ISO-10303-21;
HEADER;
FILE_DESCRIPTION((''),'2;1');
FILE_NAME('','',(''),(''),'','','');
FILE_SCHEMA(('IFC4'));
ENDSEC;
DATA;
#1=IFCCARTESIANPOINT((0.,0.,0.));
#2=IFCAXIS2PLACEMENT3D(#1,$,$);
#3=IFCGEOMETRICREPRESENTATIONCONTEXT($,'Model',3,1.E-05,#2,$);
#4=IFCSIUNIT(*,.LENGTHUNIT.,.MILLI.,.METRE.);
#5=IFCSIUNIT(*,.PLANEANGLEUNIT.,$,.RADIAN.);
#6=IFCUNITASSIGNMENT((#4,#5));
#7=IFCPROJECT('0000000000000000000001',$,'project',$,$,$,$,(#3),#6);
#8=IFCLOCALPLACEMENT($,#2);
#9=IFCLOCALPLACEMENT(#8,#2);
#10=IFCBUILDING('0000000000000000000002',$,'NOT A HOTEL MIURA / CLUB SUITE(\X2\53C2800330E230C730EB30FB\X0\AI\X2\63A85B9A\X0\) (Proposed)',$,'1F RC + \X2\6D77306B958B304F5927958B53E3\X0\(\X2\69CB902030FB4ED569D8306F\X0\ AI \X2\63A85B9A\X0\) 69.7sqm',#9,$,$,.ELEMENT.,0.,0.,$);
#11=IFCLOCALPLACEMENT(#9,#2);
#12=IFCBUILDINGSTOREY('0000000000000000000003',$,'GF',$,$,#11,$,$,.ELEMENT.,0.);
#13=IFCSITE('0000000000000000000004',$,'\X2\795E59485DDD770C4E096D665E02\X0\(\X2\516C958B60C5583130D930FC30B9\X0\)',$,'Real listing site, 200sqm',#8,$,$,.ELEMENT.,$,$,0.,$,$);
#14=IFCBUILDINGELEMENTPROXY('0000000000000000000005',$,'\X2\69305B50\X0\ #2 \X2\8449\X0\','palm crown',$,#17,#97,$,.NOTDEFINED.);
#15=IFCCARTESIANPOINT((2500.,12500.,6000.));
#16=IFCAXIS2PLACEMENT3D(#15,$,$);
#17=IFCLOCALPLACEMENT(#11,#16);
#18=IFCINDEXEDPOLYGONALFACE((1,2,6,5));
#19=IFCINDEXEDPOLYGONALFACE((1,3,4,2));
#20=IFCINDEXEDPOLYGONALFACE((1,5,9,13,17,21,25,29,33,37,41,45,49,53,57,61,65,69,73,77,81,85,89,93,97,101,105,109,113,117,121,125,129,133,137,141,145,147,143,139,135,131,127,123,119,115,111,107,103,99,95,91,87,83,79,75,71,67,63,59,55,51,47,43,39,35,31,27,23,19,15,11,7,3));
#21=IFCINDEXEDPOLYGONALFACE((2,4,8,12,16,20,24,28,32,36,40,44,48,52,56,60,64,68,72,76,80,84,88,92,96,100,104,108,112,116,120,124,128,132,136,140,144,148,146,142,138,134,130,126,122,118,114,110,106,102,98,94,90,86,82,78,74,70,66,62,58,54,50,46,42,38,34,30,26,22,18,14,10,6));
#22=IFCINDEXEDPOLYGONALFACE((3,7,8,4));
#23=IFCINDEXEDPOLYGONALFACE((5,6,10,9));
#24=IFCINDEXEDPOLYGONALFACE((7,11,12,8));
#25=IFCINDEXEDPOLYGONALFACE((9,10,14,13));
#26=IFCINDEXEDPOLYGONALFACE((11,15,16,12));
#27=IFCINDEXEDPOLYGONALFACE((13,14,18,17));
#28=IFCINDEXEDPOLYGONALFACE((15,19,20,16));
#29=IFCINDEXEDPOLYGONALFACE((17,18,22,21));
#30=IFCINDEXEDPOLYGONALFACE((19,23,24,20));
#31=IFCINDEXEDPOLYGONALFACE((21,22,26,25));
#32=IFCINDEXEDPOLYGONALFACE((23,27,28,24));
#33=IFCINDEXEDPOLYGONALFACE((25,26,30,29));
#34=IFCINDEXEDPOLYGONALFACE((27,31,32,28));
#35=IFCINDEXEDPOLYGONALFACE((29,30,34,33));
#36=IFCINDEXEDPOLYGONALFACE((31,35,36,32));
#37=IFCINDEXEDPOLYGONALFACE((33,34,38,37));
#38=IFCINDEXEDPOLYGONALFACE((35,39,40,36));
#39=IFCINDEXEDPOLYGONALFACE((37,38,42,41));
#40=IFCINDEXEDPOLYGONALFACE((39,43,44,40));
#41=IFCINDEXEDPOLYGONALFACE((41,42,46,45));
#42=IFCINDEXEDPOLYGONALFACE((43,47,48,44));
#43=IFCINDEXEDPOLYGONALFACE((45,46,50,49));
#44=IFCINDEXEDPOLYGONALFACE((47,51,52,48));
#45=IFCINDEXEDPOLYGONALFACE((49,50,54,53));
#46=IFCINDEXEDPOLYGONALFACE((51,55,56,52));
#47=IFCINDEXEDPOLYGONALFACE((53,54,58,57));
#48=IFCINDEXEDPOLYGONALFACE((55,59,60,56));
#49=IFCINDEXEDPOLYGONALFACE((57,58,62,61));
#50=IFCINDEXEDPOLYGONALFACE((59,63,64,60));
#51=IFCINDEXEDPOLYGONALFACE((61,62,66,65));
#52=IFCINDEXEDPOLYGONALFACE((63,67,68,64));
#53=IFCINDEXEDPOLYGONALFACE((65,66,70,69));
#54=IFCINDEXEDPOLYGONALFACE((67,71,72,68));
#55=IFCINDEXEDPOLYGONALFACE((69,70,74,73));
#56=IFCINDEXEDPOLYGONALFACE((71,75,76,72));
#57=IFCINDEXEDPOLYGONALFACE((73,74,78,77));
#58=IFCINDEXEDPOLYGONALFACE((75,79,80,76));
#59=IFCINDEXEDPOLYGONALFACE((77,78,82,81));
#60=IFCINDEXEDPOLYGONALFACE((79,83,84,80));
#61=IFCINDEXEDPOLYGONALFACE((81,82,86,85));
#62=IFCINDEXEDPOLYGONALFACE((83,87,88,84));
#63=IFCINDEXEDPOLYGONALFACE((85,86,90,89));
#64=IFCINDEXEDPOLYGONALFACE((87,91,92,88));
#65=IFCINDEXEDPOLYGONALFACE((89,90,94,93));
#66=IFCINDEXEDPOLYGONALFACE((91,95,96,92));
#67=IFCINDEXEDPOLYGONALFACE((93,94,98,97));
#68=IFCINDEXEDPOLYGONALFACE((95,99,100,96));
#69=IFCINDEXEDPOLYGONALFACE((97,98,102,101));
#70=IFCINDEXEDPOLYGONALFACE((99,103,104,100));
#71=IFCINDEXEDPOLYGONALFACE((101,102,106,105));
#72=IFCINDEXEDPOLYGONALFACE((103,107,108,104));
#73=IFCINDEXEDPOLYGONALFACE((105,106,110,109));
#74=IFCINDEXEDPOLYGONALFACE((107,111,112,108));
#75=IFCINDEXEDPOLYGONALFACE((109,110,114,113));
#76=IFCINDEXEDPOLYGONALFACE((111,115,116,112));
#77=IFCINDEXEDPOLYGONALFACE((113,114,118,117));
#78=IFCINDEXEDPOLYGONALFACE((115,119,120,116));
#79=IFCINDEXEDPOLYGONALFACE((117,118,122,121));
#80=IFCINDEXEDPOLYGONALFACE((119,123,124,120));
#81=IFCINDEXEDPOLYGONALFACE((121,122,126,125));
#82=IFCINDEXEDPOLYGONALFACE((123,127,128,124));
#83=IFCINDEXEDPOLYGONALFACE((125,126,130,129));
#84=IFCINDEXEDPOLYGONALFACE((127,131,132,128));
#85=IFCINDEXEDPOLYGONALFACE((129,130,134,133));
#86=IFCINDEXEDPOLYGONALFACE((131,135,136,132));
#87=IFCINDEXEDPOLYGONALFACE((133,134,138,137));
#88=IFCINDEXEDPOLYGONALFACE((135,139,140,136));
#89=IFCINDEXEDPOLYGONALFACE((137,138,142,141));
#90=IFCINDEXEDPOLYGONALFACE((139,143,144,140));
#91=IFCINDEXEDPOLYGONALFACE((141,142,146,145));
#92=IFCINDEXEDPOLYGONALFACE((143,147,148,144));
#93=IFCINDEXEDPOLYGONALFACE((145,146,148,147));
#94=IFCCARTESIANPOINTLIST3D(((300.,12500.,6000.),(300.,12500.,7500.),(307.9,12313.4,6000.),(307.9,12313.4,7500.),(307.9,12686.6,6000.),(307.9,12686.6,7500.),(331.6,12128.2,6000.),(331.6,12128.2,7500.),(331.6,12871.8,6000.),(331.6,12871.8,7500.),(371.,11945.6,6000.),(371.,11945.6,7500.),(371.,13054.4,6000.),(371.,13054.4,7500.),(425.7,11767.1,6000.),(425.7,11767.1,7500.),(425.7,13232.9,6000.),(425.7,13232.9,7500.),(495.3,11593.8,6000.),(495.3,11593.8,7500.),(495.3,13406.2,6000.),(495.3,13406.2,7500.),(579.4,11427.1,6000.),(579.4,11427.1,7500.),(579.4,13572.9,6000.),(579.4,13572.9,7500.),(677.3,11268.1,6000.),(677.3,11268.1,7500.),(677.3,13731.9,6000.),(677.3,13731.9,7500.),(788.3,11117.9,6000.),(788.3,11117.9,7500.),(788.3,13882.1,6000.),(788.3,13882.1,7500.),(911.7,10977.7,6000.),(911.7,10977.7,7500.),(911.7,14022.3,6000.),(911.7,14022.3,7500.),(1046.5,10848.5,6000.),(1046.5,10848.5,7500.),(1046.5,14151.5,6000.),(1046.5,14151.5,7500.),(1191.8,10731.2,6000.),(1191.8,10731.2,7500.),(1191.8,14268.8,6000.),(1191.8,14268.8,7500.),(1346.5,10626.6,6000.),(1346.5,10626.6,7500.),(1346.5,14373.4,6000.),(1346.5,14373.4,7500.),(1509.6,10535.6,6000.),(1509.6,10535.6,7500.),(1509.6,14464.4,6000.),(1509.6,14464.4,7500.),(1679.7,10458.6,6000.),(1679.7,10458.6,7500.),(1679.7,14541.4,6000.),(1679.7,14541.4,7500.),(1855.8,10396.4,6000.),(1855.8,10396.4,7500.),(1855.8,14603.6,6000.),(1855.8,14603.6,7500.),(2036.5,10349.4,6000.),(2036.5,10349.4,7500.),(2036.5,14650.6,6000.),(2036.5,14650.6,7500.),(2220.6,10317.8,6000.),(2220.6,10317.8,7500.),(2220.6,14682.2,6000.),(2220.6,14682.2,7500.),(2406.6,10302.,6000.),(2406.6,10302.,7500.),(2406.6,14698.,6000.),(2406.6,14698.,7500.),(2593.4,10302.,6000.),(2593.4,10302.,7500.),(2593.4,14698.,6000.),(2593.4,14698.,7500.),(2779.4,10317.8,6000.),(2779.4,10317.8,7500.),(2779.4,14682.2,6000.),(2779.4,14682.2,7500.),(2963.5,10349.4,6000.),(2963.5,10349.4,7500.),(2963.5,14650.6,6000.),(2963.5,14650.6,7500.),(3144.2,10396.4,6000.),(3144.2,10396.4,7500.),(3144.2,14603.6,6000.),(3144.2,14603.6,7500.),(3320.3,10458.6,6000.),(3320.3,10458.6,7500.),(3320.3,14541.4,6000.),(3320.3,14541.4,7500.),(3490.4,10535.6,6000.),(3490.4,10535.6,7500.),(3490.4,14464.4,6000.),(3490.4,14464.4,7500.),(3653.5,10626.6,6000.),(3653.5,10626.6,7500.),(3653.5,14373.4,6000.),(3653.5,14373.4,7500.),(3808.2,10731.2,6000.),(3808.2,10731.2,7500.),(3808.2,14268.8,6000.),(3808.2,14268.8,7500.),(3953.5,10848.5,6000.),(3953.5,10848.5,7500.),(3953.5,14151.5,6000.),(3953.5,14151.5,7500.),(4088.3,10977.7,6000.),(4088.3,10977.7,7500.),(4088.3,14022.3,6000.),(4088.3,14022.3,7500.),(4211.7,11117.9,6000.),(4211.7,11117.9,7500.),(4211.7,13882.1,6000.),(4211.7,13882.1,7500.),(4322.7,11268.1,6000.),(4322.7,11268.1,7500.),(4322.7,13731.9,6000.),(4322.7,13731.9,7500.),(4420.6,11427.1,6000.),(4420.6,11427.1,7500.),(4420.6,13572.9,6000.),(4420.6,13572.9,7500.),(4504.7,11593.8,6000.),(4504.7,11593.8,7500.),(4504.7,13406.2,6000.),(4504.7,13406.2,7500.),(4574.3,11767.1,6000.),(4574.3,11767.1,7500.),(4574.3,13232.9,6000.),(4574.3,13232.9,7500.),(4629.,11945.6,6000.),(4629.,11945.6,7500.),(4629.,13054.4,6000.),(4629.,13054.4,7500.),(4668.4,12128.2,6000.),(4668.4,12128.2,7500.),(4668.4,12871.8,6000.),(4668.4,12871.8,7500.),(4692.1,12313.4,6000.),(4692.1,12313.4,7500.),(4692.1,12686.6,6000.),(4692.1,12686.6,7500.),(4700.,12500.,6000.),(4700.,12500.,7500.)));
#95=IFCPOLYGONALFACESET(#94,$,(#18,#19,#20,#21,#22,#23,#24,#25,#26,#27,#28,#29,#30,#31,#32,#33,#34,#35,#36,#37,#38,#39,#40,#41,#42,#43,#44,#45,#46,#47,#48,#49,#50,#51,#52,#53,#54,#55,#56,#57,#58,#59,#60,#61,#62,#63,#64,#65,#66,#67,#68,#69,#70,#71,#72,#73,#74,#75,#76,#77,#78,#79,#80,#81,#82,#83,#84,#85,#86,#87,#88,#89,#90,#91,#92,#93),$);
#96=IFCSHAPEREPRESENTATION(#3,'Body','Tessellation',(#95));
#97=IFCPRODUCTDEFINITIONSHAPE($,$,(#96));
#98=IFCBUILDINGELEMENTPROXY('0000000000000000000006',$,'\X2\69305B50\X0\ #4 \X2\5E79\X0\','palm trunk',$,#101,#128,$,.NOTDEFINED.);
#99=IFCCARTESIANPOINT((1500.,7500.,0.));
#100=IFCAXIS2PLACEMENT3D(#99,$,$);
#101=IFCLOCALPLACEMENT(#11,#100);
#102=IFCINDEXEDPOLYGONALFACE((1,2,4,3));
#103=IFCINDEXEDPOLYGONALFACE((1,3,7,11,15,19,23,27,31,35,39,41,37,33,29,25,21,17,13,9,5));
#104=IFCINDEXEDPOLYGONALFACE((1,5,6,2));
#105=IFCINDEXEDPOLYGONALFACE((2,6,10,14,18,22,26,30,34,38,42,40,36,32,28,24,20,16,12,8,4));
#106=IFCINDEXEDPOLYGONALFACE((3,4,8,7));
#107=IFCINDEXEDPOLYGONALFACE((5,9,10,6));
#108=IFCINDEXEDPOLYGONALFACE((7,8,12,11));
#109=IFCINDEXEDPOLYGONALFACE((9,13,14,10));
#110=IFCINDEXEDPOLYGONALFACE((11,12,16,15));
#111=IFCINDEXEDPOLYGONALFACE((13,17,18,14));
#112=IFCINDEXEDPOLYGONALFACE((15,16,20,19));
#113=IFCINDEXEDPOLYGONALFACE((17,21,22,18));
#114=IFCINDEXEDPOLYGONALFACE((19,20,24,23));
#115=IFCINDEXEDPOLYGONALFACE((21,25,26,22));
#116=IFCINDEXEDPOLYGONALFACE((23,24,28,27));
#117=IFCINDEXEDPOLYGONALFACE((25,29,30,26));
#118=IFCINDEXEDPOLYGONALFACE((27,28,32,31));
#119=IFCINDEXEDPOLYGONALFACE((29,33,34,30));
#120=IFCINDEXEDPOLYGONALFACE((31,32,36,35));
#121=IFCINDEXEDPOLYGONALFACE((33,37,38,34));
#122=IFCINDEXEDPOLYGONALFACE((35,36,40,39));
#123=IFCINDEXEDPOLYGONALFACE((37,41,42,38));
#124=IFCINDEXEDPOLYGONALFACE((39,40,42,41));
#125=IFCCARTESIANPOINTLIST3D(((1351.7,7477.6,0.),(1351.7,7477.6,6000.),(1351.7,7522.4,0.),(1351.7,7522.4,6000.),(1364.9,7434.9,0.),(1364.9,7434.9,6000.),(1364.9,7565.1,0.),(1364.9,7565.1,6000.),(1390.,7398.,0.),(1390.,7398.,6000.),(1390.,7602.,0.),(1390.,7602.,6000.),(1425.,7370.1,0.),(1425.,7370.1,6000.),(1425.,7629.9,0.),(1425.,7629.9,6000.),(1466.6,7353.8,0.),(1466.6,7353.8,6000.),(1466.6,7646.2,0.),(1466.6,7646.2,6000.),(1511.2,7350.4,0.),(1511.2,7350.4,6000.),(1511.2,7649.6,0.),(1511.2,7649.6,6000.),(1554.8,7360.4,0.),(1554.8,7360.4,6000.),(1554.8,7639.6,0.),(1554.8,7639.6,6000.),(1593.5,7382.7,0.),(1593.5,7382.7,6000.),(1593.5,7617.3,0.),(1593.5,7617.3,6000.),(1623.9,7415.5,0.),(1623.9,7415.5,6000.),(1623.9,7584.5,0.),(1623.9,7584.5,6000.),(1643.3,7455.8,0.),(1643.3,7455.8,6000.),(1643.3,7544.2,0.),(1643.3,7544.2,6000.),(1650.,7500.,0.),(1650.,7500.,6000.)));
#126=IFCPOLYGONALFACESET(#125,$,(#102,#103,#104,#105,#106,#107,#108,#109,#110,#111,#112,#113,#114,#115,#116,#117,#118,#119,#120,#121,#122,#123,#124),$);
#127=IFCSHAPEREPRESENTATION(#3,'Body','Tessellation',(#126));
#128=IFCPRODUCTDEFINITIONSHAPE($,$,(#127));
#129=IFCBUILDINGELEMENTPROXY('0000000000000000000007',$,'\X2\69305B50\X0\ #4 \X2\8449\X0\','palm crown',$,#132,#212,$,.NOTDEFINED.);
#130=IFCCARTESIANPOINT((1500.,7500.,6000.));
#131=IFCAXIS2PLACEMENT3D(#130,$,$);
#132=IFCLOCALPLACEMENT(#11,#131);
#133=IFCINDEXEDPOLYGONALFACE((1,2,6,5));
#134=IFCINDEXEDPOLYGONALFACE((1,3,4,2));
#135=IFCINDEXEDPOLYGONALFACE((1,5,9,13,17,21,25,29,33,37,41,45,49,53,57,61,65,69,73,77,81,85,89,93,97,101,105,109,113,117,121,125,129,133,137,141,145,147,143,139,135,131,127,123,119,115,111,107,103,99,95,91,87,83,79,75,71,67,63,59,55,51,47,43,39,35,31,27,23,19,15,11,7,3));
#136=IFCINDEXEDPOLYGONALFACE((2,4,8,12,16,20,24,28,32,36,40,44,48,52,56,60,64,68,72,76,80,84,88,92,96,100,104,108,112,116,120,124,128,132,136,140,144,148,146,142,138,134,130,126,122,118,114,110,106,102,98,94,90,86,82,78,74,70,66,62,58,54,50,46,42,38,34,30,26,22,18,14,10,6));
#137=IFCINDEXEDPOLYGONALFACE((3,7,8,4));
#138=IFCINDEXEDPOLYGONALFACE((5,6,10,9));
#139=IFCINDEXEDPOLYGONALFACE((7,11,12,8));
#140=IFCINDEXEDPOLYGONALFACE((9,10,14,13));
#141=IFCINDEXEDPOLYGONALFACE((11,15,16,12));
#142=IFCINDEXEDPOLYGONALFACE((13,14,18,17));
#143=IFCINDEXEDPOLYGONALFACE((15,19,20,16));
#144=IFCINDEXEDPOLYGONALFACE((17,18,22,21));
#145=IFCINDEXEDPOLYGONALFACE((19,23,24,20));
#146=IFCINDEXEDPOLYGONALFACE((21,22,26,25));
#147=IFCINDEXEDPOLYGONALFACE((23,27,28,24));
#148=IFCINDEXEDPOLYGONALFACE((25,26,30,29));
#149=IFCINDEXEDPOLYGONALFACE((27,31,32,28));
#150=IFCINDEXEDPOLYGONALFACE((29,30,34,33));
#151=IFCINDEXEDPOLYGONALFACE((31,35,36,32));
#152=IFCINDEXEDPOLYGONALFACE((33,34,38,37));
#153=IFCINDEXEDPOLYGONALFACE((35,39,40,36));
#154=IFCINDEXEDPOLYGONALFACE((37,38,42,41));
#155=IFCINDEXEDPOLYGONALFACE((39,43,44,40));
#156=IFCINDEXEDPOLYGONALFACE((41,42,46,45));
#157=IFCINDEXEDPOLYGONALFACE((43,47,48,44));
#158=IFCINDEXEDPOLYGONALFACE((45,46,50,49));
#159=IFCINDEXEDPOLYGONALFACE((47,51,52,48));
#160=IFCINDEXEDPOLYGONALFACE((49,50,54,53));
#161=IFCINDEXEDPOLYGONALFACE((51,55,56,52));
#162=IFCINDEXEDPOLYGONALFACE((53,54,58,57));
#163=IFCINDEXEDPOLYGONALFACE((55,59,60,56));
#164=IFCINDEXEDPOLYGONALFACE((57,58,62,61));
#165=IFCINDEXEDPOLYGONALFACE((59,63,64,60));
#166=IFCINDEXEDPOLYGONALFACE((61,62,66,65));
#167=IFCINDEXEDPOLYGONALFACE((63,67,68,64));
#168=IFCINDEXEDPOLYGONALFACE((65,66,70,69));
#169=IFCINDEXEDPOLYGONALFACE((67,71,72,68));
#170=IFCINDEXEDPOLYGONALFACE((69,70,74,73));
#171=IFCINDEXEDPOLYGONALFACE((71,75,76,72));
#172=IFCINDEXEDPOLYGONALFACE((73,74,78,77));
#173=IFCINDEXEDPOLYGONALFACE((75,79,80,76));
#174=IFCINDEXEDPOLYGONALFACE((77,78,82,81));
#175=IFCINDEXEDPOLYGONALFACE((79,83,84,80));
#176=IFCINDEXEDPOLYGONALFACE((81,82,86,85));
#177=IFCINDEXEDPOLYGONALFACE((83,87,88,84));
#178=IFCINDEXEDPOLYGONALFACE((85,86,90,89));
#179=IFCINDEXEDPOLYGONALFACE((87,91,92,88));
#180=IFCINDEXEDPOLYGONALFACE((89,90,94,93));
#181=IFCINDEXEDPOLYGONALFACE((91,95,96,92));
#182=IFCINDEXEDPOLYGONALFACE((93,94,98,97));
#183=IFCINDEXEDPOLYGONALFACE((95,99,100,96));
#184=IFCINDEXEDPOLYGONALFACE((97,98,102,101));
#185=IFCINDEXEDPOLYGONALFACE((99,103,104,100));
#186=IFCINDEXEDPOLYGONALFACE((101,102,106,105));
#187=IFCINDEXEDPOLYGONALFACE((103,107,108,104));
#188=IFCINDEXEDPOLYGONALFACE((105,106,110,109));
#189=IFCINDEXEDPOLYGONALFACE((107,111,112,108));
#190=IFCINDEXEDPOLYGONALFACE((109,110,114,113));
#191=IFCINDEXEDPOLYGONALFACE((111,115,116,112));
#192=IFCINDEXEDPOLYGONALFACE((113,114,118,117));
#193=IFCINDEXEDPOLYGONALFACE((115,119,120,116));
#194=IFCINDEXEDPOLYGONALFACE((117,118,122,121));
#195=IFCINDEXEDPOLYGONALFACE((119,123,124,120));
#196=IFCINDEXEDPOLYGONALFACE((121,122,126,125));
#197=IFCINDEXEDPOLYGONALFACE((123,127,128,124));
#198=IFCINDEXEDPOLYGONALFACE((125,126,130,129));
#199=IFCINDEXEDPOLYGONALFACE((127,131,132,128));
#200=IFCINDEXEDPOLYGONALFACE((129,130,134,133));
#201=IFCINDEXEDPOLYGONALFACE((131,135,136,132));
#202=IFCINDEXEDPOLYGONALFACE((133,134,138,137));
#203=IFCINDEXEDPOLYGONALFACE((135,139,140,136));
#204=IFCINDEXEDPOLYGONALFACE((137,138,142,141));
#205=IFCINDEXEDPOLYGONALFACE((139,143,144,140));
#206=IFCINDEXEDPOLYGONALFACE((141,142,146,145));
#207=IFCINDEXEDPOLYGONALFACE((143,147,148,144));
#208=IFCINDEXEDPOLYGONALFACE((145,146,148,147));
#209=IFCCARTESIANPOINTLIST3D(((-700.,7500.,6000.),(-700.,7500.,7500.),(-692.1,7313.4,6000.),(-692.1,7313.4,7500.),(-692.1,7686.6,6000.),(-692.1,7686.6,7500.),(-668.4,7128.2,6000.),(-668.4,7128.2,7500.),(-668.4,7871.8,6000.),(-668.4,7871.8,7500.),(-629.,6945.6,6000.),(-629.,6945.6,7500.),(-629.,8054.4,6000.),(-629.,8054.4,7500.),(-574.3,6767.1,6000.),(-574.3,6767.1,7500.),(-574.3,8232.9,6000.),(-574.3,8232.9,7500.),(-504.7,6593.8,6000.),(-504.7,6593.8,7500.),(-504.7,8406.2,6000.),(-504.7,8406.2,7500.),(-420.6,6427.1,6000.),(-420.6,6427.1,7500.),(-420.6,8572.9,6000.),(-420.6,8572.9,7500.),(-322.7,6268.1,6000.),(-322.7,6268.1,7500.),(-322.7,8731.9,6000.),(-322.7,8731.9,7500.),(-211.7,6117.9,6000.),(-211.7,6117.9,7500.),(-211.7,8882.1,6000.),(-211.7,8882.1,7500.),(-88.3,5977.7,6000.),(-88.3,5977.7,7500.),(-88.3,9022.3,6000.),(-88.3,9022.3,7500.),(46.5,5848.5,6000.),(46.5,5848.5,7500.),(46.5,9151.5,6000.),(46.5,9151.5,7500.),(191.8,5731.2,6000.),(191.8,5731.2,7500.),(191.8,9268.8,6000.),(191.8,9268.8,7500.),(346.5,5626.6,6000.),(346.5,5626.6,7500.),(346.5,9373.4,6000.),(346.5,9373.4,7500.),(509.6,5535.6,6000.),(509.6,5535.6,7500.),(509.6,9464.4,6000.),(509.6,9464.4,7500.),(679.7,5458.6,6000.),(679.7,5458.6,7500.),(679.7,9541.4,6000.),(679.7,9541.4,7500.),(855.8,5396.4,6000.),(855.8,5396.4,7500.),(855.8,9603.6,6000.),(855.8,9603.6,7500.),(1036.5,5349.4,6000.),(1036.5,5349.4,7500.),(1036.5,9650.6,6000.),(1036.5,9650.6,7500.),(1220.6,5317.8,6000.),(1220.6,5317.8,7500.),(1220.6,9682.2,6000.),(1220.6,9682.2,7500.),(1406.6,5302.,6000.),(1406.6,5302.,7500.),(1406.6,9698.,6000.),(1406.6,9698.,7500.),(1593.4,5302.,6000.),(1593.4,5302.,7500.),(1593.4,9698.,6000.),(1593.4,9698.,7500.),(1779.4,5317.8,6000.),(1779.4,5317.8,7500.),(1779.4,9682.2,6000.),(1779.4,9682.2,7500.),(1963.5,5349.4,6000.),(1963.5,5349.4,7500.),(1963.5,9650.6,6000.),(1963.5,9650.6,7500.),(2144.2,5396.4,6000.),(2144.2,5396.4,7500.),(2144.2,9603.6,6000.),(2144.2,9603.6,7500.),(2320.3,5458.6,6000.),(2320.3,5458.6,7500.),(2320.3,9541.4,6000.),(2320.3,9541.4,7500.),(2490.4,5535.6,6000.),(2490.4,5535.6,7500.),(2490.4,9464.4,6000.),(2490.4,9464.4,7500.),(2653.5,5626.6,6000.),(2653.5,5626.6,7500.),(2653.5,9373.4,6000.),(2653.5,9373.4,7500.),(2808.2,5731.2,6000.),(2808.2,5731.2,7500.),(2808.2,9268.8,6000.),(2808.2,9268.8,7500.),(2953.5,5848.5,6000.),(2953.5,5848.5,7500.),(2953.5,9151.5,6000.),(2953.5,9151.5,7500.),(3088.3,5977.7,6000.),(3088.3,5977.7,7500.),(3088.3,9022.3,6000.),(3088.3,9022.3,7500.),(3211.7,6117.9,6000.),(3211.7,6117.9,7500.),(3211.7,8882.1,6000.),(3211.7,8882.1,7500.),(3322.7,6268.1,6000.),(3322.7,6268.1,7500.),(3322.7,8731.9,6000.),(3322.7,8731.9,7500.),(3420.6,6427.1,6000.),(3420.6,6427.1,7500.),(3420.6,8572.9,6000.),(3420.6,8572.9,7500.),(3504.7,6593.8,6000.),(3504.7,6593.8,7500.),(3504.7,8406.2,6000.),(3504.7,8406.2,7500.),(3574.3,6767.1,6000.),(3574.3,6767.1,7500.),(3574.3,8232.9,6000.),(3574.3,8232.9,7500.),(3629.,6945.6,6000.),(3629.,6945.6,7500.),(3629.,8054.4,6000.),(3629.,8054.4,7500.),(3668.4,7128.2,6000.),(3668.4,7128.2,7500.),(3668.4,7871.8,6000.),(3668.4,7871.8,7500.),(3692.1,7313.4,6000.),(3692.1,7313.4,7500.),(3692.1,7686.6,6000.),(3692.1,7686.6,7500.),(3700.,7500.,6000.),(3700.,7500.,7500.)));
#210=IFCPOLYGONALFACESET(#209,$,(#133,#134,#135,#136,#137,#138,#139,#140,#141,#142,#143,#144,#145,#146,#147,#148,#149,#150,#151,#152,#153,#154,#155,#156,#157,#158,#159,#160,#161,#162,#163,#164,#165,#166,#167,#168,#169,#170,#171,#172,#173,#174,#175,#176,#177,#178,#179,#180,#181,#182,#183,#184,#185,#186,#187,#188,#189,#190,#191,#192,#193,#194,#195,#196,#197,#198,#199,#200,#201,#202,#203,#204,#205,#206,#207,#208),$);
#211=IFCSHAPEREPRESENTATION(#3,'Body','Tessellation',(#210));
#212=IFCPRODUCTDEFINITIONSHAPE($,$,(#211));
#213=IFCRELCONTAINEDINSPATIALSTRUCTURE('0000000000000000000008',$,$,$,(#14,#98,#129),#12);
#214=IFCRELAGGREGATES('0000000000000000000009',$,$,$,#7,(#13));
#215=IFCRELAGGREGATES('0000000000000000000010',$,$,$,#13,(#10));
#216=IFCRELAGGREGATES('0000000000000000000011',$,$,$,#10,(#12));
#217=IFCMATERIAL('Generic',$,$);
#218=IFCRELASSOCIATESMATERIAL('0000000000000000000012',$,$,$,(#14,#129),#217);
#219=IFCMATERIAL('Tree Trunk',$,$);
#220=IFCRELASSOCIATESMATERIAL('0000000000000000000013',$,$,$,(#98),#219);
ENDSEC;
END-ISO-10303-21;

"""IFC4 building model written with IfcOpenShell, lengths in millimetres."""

from ifc_helpers import new_model, si_unit, frame, origin, origin_2d, place, context, project, spatial, circle, extrude, material, element, save


model = new_model("IFC4")

# Units and contexts
model_context = context("Model", 3, precision=1e-05, world=origin())
ifc_project = project(units=[si_unit("LENGTHUNIT", "METRE", prefix="MILLI"), si_unit("PLANEANGLEUNIT", "RADIAN")], contexts=[model_context])

# Site, building, storey
site_placement = place(None, origin())
site = spatial("IfcSite", under=ifc_project, at=site_placement, Name="神奈川県三浦市(公開情報ベース)", ObjectType="Real listing site, 200sqm", CompositionType="ELEMENT", RefElevation=0.0)
building_placement = place(site_placement, origin())
building = spatial("IfcBuilding", under=site, at=building_placement, Name="NOT A HOTEL MIURA / CLUB SUITE(参考モデル・AI推定) (Proposed)", ObjectType="1F RC + 海に開く大開口(構造・仕様は AI 推定) 69.7sqm", CompositionType="ELEMENT", ElevationOfRefHeight=0.0, ElevationOfTerrain=0.0)
storey_placement = place(building_placement, origin())
storey = spatial("IfcBuildingStorey", under=building, at=storey_placement, Name="GF", CompositionType="ELEMENT", Elevation=0.0)

# Shared definitions
ifc_material_1 = material(Name="Generic")

# Building element proxies
ifc_material_2 = material(Name="Tree Trunk")
proxy_1_placement = place(storey_placement, frame((2500.0, 12500.0, 6000.0)))
element("IfcBuildingElementProxy", 1, at=proxy_1_placement, inside=storey, material=ifc_material_1, Name="椰子 #2 葉", Description="palm crown", PredefinedType="NOTDEFINED", context=model_context, shape_type="SweptSolid", body=[
    extrude(circle(Radius=2200.0, at=origin_2d()), frame((2500.0, 12500.0, 6000.0)), (0.0, 0.0, 1.0), 1500.0),
])
proxy_2_placement = place(storey_placement, frame((1500.0, 7500.0, 0.0)))
element("IfcBuildingElementProxy", 2, at=proxy_2_placement, inside=storey, material=ifc_material_2, Name="椰子 #4 幹", Description="palm trunk", PredefinedType="NOTDEFINED", context=model_context, shape_type="SweptSolid", body=[
    extrude(circle(Radius=150.0, at=origin_2d()), frame((1500.0, 7500.0, 0.0)), (0.0, 0.0, 1.0), 6000.0),
])
proxy_3_placement = place(storey_placement, frame((1500.0, 7500.0, 6000.0)))
element("IfcBuildingElementProxy", 3, at=proxy_3_placement, inside=storey, material=ifc_material_1, Name="椰子 #4 葉", Description="palm crown", PredefinedType="NOTDEFINED", context=model_context, shape_type="SweptSolid", body=[
    extrude(circle(Radius=2200.0, at=origin_2d()), frame((1500.0, 7500.0, 6000.0)), (0.0, 0.0, 1.0), 1500.0),
])

save(model, "model.ifc")
